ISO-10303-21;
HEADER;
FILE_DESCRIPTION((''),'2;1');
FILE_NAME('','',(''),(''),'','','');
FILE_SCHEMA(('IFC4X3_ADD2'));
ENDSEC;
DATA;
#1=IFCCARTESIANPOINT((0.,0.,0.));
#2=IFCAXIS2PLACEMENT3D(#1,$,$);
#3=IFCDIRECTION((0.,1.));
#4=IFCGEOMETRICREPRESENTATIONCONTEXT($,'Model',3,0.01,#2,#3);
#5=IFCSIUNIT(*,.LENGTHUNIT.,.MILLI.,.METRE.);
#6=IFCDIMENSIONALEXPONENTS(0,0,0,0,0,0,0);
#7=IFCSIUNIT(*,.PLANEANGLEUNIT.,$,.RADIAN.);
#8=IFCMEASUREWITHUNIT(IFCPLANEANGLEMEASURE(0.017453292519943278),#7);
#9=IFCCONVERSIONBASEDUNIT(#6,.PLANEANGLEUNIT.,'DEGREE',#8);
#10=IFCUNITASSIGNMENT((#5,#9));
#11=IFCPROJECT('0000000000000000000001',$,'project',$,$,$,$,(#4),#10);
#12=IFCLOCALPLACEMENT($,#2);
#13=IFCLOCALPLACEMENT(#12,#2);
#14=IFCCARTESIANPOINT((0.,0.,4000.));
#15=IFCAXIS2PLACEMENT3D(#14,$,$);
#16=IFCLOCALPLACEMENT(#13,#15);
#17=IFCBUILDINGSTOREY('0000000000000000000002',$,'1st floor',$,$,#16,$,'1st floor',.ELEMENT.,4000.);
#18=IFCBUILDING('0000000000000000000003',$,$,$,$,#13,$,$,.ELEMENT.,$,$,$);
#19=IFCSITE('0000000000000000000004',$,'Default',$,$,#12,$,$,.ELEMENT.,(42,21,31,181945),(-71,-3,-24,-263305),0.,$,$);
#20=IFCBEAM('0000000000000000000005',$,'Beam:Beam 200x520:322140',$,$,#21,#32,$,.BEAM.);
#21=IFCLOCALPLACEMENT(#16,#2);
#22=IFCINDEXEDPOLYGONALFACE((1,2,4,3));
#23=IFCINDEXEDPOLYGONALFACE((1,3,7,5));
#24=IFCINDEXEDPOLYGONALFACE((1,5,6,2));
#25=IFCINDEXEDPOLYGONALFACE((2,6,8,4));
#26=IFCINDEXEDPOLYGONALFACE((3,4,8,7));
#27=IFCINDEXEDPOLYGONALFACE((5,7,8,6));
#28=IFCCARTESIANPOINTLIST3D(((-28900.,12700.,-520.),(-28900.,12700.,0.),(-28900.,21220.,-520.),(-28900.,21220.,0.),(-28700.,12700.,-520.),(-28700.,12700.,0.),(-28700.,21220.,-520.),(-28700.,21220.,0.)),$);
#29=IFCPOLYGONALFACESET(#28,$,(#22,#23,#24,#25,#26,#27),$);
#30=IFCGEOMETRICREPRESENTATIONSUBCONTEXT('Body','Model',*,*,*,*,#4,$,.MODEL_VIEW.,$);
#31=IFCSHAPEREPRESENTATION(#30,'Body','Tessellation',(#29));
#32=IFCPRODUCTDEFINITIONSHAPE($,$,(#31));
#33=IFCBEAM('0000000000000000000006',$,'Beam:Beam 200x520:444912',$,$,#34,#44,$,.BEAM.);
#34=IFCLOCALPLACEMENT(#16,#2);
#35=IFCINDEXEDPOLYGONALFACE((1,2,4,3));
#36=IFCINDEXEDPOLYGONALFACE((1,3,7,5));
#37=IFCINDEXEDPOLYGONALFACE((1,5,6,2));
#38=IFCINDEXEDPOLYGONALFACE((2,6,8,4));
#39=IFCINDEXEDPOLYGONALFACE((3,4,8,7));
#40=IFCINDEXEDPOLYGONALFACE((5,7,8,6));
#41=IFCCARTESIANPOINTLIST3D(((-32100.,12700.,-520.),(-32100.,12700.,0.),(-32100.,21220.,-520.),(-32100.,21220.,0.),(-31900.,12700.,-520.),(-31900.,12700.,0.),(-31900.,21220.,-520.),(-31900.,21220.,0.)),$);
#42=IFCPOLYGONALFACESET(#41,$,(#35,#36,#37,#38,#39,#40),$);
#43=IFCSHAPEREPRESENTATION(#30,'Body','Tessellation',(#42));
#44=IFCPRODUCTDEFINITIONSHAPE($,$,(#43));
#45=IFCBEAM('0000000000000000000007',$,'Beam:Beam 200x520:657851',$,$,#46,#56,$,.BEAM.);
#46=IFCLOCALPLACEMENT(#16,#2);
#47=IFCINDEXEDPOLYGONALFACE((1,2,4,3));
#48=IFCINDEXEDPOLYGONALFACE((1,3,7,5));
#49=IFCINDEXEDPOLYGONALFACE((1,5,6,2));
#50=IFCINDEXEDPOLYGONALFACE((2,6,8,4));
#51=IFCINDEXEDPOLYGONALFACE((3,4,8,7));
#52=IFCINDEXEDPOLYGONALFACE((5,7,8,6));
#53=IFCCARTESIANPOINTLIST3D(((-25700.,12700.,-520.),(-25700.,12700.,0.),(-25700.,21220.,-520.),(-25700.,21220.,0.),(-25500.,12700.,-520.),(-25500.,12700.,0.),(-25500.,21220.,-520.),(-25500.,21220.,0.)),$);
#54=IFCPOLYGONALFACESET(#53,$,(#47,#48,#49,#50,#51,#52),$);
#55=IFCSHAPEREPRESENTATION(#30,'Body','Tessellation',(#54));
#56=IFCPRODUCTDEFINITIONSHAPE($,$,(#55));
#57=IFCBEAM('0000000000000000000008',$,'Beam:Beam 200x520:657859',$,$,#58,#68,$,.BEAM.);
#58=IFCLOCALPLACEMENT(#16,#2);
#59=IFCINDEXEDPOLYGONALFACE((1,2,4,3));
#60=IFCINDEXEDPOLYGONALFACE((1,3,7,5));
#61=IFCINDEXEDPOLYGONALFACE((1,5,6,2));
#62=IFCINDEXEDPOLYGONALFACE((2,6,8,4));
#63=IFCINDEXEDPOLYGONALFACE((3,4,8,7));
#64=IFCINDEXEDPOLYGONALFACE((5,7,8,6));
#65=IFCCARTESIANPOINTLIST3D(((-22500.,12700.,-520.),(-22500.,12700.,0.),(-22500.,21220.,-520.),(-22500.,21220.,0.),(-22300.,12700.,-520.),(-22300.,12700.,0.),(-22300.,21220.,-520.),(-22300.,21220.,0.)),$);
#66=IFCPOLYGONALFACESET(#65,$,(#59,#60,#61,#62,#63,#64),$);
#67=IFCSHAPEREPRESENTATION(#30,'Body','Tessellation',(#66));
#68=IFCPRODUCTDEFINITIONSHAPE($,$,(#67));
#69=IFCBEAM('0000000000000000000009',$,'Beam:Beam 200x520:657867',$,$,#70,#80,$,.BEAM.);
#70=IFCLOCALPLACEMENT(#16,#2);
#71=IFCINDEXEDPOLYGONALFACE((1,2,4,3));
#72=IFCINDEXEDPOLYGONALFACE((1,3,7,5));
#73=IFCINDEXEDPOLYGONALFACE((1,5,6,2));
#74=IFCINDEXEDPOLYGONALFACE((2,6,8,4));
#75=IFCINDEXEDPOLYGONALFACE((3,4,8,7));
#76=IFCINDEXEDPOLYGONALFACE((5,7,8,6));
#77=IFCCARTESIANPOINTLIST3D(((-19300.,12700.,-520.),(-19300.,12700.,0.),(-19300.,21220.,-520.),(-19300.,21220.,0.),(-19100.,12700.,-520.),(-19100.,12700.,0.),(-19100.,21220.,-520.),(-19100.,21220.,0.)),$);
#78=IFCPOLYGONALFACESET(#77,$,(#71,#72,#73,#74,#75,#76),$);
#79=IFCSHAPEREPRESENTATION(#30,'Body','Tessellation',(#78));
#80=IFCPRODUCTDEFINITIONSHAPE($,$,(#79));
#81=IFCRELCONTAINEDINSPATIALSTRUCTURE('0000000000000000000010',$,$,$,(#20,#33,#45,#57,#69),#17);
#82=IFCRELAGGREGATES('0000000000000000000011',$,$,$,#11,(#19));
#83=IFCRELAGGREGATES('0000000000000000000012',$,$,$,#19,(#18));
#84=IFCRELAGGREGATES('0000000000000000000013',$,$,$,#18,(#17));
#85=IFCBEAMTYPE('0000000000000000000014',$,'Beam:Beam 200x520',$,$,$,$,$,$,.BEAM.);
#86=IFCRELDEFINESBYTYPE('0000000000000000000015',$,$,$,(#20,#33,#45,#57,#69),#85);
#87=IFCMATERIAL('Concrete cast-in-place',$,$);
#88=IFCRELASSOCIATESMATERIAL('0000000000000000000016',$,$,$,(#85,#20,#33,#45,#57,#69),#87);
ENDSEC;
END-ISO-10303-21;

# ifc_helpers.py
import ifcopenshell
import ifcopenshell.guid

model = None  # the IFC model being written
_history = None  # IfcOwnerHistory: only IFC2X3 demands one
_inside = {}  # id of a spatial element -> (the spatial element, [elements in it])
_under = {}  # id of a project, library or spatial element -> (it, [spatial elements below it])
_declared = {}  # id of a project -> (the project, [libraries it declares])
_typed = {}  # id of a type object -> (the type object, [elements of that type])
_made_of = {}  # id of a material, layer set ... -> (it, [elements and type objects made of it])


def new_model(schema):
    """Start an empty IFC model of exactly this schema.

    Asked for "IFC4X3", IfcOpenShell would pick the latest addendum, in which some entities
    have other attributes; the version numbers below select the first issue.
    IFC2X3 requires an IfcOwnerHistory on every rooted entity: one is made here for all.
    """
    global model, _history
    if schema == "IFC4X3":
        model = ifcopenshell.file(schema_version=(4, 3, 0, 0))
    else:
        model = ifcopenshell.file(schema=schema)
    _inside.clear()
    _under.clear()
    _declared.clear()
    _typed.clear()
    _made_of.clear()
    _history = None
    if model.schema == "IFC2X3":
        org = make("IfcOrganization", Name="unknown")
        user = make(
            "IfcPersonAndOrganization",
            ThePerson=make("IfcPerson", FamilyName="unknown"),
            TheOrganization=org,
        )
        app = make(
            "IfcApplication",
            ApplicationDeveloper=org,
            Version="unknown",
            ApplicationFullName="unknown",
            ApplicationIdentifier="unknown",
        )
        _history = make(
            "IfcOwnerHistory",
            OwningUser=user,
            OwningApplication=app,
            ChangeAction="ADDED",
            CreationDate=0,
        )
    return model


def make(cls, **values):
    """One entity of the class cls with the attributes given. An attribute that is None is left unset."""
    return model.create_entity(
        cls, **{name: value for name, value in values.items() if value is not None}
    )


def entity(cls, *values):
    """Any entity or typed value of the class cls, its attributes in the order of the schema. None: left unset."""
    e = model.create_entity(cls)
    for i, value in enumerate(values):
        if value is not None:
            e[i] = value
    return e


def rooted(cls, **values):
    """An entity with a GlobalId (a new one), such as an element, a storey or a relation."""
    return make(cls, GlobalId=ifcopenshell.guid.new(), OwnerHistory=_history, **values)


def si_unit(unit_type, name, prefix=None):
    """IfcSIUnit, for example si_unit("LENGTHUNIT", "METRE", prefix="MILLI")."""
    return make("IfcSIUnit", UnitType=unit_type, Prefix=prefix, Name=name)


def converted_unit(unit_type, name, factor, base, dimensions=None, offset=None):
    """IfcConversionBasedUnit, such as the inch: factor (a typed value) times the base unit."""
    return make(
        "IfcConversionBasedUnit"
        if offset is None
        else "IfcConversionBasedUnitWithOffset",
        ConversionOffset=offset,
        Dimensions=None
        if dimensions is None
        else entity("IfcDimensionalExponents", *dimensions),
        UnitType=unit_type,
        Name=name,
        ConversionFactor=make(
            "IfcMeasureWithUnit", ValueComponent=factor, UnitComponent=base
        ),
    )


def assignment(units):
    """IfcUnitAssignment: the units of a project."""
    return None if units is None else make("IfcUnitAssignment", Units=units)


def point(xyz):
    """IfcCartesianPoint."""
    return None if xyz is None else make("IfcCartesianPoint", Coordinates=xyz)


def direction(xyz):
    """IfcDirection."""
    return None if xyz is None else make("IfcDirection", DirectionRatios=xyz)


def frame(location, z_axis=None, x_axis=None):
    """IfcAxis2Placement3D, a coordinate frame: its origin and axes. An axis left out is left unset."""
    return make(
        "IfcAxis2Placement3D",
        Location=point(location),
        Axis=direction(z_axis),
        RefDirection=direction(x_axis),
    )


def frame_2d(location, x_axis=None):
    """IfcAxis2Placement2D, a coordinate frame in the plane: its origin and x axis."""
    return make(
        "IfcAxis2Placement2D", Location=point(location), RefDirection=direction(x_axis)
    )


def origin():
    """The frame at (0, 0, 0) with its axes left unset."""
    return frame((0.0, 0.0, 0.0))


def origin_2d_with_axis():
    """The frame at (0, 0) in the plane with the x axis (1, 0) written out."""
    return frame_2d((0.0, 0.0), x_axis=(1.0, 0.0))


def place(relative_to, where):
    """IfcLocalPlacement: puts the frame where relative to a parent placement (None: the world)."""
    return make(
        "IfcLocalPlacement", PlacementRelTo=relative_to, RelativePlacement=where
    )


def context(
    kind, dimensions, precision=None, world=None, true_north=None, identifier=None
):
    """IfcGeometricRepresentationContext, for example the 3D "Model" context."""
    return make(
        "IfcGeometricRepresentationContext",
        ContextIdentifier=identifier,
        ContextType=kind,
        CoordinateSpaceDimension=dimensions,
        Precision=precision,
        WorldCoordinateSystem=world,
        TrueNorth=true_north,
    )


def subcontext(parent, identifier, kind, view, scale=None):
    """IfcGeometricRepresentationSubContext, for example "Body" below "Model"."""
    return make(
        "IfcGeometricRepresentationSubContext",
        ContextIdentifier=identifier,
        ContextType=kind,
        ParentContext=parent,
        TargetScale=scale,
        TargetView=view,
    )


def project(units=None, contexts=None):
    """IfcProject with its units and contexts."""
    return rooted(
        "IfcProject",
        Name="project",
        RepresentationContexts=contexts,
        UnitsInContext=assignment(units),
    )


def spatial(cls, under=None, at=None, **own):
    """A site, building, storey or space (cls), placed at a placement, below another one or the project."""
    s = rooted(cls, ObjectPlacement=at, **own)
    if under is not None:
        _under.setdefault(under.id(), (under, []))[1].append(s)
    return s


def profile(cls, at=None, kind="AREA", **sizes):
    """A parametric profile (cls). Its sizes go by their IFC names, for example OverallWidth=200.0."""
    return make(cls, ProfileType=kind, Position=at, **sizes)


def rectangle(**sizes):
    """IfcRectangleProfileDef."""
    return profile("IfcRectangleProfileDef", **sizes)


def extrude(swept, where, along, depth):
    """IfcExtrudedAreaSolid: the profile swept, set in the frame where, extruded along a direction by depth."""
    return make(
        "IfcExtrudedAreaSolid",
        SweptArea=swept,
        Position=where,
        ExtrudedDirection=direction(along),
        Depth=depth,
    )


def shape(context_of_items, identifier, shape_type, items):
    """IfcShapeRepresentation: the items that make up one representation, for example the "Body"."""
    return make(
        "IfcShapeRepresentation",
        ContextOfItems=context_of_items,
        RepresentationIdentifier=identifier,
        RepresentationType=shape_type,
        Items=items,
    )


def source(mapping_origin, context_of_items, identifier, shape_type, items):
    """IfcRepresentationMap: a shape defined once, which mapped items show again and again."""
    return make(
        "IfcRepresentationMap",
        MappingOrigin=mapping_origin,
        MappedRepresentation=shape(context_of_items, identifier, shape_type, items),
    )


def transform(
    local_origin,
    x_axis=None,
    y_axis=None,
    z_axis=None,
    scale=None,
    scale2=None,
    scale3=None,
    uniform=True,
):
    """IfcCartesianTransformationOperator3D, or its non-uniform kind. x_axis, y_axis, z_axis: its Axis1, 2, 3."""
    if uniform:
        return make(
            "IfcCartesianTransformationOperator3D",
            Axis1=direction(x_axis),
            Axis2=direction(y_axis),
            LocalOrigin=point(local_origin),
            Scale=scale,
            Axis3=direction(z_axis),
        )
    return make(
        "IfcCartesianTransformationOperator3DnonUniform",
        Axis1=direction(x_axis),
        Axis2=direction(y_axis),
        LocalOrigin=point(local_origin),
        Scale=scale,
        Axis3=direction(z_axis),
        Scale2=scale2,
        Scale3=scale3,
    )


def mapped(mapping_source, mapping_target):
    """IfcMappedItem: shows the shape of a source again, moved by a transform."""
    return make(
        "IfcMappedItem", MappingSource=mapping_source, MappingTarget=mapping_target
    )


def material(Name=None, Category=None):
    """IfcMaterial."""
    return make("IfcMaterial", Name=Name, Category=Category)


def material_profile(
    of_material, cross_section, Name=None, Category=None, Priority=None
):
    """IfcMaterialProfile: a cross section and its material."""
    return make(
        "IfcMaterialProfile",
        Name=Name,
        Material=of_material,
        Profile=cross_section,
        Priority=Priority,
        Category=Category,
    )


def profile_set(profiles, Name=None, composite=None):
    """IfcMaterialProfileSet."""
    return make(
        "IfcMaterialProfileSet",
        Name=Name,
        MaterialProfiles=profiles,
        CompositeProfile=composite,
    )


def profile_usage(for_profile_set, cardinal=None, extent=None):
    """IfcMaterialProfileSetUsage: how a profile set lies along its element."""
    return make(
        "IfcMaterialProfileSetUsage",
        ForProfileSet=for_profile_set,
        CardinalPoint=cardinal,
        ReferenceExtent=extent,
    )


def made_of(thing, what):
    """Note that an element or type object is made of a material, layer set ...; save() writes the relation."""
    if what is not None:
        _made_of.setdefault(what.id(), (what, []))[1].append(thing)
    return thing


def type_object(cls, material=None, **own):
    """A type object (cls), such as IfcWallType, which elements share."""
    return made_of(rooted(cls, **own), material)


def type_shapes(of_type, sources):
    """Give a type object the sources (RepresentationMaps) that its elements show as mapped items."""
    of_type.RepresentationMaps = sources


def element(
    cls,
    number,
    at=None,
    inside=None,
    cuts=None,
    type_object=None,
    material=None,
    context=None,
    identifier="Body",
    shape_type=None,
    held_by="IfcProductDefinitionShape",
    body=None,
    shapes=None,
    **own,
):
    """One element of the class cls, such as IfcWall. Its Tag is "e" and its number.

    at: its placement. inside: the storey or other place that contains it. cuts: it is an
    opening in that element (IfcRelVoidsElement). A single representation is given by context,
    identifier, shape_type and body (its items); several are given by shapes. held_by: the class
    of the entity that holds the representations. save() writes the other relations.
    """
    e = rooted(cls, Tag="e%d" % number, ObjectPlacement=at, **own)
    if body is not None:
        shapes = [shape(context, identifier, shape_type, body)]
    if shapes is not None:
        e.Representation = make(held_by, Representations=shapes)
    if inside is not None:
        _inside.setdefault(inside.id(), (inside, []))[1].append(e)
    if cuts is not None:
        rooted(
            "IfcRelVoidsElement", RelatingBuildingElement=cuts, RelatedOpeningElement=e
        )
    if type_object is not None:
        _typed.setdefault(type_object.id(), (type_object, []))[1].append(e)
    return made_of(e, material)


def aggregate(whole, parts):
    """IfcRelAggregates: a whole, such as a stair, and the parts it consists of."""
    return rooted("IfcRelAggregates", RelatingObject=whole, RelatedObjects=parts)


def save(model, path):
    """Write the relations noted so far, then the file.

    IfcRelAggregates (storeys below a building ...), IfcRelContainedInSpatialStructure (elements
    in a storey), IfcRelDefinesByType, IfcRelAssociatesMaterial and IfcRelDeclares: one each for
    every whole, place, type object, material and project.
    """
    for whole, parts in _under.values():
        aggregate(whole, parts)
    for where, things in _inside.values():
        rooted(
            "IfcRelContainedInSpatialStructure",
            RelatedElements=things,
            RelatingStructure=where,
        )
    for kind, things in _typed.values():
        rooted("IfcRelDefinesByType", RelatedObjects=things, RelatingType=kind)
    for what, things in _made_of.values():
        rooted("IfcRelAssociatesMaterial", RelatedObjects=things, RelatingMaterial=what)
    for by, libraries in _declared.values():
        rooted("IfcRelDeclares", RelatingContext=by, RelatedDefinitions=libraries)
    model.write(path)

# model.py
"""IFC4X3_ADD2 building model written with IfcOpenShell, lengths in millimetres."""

from ifc_helpers import new_model, entity, si_unit, converted_unit, direction, frame, origin, origin_2d_with_axis, place, context, subcontext, project, spatial, rectangle, extrude, source, transform, mapped, material, material_profile, profile_set, profile_usage, type_object, type_shapes, element, save


model = new_model("IFC4X3_ADD2")

# Units and contexts
model_context = context("Model", 3, precision=0.01, world=origin(), true_north=direction((0.0, 1.0)))
body_context = subcontext(model_context, "Body", "Model", "MODEL_VIEW")
ifc_project = project(units=[si_unit("LENGTHUNIT", "METRE", prefix="MILLI"), converted_unit("PLANEANGLEUNIT", "DEGREE", entity("IfcPlaneAngleMeasure", 0.017453292519943278), si_unit("PLANEANGLEUNIT", "RADIAN"), dimensions=[0, 0, 0, 0, 0, 0, 0])], contexts=[model_context])

# Site, building, storey
site_placement = place(None, origin())
site = spatial("IfcSite", under=ifc_project, at=site_placement, Name="Default", CompositionType="ELEMENT", RefLatitude=(42, 21, 31, 181945), RefLongitude=(-71, -3, -24, -263305), RefElevation=0.0)
building_placement = place(site_placement, origin())
building = spatial("IfcBuilding", under=site, at=building_placement, CompositionType="ELEMENT")
storey_placement = place(building_placement, frame((0.0, 0.0, 4000.0)))
storey = spatial("IfcBuildingStorey", under=building, at=storey_placement, Name="1st floor", LongName="1st floor", CompositionType="ELEMENT", Elevation=4000.0)

# Beams
ifc_material_1 = material(Name="Concrete cast-in-place")
ifc_material_profile_1 = material_profile(ifc_material_1, rectangle(XDim=8520.0, YDim=200.0, at=origin_2d_with_axis()), Name="Beam 200x520")
ifc_profile_set_1 = profile_set([ifc_material_profile_1], Name="Beam 200x520")
ifc_profile_usage_1 = profile_usage(ifc_profile_set_1, cardinal=8)
beam_type = type_object("IfcBeamType", Name="Beam:Beam 200x520", PredefinedType="BEAM", material=ifc_profile_set_1)
shared_shape_1 = source(origin(), body_context, "Body", "SweptSolid", [
    extrude(rectangle(XDim=8520.0, YDim=200.0, at=origin_2d_with_axis()), frame((0.0, 0.0, -260.0), z_axis=(0.0, 0.0, 1.0), x_axis=(-1.0, 0.0, 0.0)), (0.0, 0.0, 1.0), 520.0),
])
type_shapes(beam_type, [shared_shape_1])
for number, where, z_axis, x_axis, name in (
    (1, (-28800.0, 16960.0, -260.0), (0.0, 0.0, 1.0), (0.0, -1.0, 0.0), "Beam:Beam 200x520:322140"),
    (2, (-32000.0, 16960.0, -260.0), (0.0, 0.0, 1.0), (0.0, -1.0, 0.0), "Beam:Beam 200x520:444912"),
    (3, (-25600.0, 16960.0, -260.0), (0.0, 0.0, 1.0), (0.0, -1.0, 0.0), "Beam:Beam 200x520:657851"),
    (4, (-22400.0, 16960.0, -260.0), (0.0, 0.0, 1.0), (0.0, -1.0, 0.0), "Beam:Beam 200x520:657859"),
    (5, (-19200.0, 16960.0, -260.0), (0.0, 0.0, 1.0), (0.0, -1.0, 0.0), "Beam:Beam 200x520:657867"),
):
    element("IfcBeam", number, at=place(storey_placement, frame(where, z_axis=z_axis, x_axis=x_axis)), inside=storey, type_object=beam_type, material=ifc_profile_usage_1, Name=name, PredefinedType="BEAM", context=body_context, shape_type="MappedRepresentation", body=[
        mapped(shared_shape_1, transform((0.0, 0.0, 0.0), scale=1.0)),
    ])

save(model, "model.ifc")
